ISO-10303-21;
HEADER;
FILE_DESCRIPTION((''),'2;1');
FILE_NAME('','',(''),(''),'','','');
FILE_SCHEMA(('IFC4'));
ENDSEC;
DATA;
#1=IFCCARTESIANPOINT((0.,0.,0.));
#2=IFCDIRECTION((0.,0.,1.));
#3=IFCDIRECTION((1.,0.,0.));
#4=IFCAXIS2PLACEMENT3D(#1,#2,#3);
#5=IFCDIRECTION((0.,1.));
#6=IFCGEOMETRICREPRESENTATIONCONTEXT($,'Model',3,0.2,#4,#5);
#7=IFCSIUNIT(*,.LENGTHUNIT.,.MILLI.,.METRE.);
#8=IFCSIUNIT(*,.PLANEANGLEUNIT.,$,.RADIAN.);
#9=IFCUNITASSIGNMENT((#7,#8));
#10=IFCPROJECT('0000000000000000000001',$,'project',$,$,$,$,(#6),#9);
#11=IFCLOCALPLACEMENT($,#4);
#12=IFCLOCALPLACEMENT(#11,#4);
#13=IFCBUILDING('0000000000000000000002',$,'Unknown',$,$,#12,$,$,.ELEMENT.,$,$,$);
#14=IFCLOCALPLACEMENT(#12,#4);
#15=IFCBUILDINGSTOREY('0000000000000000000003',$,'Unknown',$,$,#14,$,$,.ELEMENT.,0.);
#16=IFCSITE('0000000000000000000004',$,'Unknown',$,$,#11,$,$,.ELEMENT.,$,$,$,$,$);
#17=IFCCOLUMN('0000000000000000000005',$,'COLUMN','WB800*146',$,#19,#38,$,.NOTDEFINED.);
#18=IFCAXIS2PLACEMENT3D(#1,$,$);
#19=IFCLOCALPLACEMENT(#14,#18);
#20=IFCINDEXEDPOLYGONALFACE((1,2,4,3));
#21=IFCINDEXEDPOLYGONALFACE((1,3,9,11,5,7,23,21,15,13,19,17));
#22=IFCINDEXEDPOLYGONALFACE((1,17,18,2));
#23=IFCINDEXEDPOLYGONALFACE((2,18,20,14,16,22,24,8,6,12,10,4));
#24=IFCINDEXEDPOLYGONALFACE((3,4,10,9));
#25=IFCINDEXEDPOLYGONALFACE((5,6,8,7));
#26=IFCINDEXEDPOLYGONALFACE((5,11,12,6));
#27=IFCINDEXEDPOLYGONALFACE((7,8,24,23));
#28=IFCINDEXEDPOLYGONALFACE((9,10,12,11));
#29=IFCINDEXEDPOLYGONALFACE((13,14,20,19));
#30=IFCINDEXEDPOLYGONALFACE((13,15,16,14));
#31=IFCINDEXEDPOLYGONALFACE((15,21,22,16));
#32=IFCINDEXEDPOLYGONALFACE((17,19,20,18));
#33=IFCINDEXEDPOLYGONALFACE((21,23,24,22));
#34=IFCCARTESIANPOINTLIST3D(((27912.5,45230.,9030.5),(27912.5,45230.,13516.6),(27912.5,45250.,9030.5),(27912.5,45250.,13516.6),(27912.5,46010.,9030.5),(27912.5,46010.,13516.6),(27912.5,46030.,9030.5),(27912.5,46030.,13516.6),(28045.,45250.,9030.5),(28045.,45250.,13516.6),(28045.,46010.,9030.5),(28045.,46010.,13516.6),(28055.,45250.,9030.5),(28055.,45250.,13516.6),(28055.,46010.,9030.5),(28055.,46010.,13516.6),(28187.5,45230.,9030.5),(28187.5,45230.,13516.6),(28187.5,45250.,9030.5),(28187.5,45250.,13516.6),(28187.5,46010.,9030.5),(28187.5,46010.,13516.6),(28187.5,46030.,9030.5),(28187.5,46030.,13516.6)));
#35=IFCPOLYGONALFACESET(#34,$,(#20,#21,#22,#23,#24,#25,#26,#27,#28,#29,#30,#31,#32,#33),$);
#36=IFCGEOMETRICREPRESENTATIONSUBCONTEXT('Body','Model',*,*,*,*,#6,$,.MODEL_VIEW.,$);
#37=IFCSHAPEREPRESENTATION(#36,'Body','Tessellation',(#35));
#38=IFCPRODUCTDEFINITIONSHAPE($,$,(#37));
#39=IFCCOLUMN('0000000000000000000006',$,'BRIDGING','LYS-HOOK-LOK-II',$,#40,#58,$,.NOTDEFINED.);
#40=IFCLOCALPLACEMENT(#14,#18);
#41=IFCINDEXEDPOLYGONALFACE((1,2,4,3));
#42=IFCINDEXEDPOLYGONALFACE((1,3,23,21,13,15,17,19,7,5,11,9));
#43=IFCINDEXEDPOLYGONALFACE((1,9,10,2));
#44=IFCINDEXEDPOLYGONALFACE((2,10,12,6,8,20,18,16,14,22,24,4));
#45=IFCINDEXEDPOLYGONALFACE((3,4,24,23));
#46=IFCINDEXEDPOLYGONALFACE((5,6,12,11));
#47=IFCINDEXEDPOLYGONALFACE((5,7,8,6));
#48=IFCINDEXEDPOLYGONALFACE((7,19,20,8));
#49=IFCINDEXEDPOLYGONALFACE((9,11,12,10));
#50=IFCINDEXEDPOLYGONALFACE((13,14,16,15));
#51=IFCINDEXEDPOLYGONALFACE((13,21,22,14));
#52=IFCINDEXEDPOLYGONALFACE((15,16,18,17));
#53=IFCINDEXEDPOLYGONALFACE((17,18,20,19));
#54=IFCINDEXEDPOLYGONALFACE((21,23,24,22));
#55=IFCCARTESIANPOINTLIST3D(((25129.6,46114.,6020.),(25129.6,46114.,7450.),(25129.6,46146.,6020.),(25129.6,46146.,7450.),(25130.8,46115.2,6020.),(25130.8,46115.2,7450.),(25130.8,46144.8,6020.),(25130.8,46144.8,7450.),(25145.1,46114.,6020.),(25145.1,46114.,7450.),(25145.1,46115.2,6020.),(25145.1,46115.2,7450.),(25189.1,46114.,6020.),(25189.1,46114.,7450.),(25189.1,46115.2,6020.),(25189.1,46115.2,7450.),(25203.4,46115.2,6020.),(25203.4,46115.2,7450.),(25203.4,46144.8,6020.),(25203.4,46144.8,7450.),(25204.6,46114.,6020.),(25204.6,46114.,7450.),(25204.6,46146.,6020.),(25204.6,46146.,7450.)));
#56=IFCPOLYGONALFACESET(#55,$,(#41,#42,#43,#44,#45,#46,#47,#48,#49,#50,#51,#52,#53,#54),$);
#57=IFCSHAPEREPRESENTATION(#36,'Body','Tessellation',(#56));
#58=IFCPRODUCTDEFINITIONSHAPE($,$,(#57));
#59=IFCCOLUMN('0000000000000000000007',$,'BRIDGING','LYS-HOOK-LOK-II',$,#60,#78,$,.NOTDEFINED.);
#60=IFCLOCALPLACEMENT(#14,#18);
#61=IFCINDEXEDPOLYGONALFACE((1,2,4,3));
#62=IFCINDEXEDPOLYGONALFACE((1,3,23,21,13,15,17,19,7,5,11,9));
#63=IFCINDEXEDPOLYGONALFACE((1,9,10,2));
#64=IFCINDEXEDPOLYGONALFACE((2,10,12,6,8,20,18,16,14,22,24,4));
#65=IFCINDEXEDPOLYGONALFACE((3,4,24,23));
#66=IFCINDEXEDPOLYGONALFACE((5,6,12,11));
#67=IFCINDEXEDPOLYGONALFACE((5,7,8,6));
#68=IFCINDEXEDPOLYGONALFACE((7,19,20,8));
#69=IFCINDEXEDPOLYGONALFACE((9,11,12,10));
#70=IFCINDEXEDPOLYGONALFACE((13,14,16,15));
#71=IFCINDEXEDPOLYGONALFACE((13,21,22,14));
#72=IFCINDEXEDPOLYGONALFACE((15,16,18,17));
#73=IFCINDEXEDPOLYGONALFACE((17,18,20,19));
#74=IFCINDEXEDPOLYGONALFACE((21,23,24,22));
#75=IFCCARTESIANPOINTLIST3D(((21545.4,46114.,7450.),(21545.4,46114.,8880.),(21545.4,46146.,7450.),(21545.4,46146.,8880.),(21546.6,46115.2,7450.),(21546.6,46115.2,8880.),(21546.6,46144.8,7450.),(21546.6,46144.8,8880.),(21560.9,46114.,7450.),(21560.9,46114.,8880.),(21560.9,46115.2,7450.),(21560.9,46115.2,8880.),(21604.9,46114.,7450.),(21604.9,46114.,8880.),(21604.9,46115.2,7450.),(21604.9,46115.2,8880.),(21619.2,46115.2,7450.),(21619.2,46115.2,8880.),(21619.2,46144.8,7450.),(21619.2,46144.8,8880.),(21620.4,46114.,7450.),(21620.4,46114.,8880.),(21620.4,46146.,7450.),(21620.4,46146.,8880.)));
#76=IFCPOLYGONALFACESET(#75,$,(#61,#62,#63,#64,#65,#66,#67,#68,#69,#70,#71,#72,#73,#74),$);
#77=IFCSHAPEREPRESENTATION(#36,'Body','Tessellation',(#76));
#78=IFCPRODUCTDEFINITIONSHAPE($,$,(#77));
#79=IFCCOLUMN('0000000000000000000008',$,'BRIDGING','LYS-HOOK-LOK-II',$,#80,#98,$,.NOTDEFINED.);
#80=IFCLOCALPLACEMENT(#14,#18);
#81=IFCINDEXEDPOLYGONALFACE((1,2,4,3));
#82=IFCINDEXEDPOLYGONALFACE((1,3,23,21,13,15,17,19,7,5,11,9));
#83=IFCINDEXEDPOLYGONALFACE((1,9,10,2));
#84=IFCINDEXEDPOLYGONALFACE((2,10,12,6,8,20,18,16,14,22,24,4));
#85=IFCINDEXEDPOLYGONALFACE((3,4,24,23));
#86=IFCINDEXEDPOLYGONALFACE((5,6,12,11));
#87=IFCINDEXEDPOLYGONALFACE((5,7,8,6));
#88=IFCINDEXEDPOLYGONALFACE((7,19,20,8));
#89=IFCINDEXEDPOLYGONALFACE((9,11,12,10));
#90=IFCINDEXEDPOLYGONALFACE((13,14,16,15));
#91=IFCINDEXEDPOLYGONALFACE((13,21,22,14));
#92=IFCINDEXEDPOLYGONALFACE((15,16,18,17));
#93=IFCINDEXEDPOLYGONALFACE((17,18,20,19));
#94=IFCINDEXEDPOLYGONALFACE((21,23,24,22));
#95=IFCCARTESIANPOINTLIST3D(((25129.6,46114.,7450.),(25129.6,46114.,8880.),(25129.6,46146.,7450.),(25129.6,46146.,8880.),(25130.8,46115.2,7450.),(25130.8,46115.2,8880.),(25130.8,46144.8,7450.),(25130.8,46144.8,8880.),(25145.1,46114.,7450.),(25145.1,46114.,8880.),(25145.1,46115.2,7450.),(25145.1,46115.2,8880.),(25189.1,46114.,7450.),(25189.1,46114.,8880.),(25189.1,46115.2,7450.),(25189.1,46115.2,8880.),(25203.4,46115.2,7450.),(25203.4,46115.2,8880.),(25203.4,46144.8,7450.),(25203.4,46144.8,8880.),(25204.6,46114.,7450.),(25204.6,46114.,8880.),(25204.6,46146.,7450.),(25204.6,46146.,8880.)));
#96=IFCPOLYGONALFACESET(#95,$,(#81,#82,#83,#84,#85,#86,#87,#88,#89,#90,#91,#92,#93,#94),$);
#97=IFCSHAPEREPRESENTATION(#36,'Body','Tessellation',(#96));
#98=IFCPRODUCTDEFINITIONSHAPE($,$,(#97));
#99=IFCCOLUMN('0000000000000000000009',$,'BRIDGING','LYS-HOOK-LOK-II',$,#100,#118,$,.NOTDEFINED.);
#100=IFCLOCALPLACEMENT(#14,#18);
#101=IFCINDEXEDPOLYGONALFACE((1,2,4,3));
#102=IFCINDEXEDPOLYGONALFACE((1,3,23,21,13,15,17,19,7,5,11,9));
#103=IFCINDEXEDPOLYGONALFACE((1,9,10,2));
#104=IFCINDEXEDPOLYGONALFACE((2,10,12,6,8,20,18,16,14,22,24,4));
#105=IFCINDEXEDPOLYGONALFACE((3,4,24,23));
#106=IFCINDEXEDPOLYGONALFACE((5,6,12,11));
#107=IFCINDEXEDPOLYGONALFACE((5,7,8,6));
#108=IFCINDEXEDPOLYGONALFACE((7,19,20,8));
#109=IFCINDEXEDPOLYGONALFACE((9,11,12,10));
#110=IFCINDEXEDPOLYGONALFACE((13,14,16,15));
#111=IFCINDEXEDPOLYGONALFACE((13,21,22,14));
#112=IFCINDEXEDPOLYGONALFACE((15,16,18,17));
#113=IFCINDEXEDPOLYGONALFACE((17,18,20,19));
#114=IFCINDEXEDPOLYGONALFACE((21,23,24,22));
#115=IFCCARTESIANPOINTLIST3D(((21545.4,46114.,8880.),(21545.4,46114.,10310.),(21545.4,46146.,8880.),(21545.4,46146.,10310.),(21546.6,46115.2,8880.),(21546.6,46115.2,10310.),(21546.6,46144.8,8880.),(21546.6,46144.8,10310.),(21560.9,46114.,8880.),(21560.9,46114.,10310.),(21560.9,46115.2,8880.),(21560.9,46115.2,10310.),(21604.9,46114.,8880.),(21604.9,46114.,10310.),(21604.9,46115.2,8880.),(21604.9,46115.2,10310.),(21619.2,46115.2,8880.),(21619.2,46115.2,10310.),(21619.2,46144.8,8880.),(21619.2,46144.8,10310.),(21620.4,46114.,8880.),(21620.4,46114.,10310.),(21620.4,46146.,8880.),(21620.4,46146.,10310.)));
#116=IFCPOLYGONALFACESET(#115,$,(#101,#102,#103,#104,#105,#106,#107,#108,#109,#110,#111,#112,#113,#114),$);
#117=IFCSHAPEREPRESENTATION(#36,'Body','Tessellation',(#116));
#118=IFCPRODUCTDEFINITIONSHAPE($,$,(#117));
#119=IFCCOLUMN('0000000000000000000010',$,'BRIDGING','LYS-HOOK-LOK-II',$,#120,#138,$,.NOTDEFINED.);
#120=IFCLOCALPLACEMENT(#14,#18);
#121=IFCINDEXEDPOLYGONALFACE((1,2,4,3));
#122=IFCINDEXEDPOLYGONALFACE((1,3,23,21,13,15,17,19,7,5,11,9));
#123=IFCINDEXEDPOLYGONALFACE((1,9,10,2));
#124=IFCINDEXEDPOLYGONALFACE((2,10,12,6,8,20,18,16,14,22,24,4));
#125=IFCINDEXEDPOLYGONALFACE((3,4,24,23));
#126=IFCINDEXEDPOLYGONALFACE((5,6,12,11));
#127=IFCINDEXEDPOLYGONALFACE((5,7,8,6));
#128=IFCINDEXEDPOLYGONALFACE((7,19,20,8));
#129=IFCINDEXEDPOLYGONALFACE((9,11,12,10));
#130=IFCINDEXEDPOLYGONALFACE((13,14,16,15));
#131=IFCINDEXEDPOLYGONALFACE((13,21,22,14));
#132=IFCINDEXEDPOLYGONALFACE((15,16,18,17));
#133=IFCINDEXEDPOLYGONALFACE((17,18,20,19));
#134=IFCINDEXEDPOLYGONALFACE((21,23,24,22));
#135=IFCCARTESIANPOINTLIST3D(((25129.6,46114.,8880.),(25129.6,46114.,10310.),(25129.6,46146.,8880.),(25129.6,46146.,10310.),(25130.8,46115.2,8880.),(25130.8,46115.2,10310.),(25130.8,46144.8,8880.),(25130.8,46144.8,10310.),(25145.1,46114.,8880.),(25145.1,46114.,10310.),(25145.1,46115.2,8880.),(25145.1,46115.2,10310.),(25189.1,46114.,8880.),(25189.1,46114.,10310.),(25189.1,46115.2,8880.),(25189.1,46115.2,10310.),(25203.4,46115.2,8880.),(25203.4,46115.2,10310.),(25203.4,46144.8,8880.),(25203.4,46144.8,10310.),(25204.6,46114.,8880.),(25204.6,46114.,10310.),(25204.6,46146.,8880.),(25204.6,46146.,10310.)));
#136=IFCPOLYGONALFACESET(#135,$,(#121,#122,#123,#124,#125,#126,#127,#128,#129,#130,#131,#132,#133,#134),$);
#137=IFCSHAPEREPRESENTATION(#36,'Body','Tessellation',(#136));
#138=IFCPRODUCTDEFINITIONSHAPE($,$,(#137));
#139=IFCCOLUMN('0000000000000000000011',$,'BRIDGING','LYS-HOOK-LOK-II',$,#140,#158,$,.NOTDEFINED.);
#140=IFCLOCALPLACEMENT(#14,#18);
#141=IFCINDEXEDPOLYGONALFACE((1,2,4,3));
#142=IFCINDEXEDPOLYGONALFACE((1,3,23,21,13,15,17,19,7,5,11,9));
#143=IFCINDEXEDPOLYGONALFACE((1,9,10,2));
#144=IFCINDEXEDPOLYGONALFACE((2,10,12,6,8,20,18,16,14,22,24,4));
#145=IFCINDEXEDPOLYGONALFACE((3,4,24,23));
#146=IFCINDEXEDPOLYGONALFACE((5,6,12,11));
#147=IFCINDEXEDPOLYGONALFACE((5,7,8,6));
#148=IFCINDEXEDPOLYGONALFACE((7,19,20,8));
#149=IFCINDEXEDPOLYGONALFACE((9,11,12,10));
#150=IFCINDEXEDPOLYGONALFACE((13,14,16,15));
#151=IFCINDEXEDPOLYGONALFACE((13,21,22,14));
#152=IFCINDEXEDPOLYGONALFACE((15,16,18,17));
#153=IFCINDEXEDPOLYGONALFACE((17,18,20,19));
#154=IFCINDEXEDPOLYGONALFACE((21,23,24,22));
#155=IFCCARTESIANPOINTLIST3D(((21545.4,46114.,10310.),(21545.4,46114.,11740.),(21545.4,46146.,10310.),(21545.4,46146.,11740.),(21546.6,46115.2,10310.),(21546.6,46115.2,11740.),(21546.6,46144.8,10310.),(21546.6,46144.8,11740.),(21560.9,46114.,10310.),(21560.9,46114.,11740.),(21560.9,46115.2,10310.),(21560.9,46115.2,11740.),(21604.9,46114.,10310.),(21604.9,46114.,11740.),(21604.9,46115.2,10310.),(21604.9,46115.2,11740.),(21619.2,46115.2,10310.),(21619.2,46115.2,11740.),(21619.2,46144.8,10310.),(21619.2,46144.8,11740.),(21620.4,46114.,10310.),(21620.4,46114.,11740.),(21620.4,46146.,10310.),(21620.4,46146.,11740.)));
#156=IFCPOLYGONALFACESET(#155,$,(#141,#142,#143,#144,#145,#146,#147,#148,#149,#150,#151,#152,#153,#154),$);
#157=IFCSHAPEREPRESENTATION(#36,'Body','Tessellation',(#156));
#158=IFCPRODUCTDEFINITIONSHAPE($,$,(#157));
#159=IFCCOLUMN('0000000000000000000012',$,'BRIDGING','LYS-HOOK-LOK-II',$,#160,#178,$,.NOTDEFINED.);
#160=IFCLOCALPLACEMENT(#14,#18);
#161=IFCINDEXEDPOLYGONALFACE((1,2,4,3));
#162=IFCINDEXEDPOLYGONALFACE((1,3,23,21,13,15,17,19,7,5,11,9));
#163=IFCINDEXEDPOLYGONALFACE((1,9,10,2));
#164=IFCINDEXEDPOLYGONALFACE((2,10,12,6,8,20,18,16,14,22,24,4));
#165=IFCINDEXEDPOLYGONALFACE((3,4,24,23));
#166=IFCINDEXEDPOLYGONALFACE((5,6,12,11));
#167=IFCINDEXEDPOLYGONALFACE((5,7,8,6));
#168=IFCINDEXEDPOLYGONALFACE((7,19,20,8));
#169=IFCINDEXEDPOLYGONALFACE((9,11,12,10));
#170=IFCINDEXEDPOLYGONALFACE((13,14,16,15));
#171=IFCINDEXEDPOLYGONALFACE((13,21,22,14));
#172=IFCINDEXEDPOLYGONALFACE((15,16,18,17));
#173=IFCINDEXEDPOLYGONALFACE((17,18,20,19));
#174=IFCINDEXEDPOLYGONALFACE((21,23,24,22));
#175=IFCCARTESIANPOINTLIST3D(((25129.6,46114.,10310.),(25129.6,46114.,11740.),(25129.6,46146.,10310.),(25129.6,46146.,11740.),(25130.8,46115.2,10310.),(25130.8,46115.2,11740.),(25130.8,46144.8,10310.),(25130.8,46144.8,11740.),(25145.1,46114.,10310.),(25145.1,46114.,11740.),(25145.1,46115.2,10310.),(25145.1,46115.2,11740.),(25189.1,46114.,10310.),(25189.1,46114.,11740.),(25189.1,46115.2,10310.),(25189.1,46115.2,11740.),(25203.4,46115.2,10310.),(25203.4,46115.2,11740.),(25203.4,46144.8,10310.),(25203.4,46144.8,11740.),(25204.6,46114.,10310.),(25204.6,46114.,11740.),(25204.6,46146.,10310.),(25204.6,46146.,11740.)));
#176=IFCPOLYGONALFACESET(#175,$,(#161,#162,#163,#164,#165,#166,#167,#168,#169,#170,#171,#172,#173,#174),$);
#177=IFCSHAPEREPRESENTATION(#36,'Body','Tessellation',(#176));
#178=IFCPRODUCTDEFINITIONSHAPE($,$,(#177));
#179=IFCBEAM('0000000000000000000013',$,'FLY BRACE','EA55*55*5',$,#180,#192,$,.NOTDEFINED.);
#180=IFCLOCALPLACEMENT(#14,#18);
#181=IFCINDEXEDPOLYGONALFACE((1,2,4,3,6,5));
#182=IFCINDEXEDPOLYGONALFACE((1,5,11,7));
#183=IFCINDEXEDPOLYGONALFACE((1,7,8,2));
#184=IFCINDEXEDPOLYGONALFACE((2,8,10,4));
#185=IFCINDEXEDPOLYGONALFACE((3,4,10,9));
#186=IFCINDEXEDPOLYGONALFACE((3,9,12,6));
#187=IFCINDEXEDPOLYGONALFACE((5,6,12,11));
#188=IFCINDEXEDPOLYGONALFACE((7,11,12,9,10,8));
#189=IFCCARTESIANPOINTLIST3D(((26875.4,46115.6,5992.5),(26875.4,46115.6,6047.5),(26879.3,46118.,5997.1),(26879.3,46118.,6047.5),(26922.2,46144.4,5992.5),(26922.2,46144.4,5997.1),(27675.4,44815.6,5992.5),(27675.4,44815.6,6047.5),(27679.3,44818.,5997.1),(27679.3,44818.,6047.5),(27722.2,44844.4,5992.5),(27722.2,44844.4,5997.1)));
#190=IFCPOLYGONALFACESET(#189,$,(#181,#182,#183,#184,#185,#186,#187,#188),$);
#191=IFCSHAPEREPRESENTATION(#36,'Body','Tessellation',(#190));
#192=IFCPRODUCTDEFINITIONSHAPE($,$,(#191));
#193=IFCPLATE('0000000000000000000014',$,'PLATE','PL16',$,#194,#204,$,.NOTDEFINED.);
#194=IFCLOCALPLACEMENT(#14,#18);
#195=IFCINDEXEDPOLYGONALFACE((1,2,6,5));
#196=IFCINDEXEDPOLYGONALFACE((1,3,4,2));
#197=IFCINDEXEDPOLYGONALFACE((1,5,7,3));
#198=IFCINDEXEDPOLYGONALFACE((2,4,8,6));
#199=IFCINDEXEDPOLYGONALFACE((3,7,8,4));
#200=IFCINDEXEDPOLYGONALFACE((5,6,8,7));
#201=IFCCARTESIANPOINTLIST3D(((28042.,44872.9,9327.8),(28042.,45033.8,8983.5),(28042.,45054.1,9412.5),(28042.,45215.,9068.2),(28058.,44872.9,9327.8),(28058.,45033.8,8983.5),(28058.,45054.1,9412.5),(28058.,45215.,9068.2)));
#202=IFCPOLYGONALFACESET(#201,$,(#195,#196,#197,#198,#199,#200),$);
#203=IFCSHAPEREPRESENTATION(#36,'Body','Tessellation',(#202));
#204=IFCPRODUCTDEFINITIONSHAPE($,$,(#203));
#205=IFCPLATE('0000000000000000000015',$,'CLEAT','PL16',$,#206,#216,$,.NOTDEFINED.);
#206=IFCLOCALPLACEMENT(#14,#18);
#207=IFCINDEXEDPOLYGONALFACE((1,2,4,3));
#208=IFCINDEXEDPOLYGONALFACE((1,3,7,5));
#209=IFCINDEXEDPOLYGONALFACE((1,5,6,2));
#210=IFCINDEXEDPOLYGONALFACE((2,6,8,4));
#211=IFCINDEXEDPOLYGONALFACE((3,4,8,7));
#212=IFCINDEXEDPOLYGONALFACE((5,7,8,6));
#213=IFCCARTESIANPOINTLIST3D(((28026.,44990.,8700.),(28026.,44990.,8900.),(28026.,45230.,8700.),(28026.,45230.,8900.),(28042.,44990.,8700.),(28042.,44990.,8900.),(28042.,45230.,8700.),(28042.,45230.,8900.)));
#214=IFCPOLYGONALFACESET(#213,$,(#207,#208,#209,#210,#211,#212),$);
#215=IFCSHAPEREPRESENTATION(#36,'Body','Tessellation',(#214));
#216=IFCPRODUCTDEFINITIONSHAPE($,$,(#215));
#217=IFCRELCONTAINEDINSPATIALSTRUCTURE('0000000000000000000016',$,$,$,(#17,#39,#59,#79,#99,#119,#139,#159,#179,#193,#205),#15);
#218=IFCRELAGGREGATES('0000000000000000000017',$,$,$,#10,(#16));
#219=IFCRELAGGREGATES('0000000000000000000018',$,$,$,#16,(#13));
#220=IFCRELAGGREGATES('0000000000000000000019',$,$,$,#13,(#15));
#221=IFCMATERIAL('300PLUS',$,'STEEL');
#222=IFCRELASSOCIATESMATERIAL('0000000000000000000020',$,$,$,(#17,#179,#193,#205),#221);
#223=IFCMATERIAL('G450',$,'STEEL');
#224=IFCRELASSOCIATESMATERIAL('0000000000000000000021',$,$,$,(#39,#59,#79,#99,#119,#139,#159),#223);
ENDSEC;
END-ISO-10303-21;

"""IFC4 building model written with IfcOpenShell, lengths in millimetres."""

from ifc_helpers import new_model, si_unit, direction, frame, origin_with_axes, place, context, subcontext, project, spatial, line, indexed_curve, outline, extrude, material, element, save


model = new_model("IFC4")

# Units and contexts
model_context = context("Model", 3, precision=0.2, world=origin_with_axes(), true_north=direction((0.0, 1.0)))
body_context = subcontext(model_context, "Body", "Model", "MODEL_VIEW")
ifc_project = project(units=[si_unit("LENGTHUNIT", "METRE", prefix="MILLI"), si_unit("PLANEANGLEUNIT", "RADIAN")], contexts=[model_context])

# Site, building, storey
site_placement = place(None, origin_with_axes())
site = spatial("IfcSite", under=ifc_project, at=site_placement, Name="Unknown", CompositionType="ELEMENT")
building_placement = place(site_placement, origin_with_axes())
building = spatial("IfcBuilding", under=site, at=building_placement, Name="Unknown", CompositionType="ELEMENT")
storey_placement = place(building_placement, origin_with_axes())
storey = spatial("IfcBuildingStorey", under=building, at=storey_placement, Name="Unknown", CompositionType="ELEMENT", Elevation=0.0)

# Columns
ifc_material_1 = material(Name="300PLUS", Category="STEEL")
column_placement = place(storey_placement, frame((28050.0, 45630.0, 9030.5), z_axis=(-1.0, 0.0, 0.0), x_axis=(0.0, 0.0, 1.0)))
element("IfcColumn", 1, at=column_placement, inside=storey, material=ifc_material_1, Name="COLUMN", Description="WB800*146", PredefinedType="NOTDEFINED", context=body_context, shape_type="SolidModel", body=[
    extrude(outline(indexed_curve([(-137.5, -400.0), (137.5, -400.0), (137.5, -380.0), (5.0, -380.0), (5.0, 380.0), (137.5, 380.0), (137.5, 400.0), (-137.5, 400.0), (-137.5, 380.0), (-5.0, 380.0), (-5.0, -380.0), (-137.5, -380.0)], segments=[line(1, 2, 3, 4, 5, 6, 7, 8, 9, 10, 11, 12, 1)])), frame((0.0, 0.0, 0.0), z_axis=(-1.0, 0.0, 0.0), x_axis=(0.0, 0.0, 1.0)), (0.0, 0.0, -1.0), 4486.1),
])
ifc_material_2 = material(Name="G450", Category="STEEL")
for number, where, z_axis, x_axis, name in (
    (2, (25167.1, 46130.0, 6020.0), (0.0, -1.0, 0.0), (0.0, 0.0, 1.0), "BRIDGING"),
    (3, (21582.9, 46130.0, 7450.0), (0.0, -1.0, 0.0), (0.0, 0.0, 1.0), "BRIDGING"),
    (4, (25167.1, 46130.0, 7450.0), (0.0, -1.0, 0.0), (0.0, 0.0, 1.0), "BRIDGING"),
    (5, (21582.9, 46130.0, 8880.0), (0.0, -1.0, 0.0), (0.0, 0.0, 1.0), "BRIDGING"),
    (6, (25167.1, 46130.0, 8880.0), (0.0, -1.0, 0.0), (0.0, 0.0, 1.0), "BRIDGING"),
    (7, (21582.9, 46130.0, 10310.0), (0.0, -1.0, 0.0), (0.0, 0.0, 1.0), "BRIDGING"),
    (8, (25167.1, 46130.0, 10310.0), (0.0, -1.0, 0.0), (0.0, 0.0, 1.0), "BRIDGING"),
):
    element("IfcColumn", number, at=place(storey_placement, frame(where, z_axis=z_axis, x_axis=x_axis)), inside=storey, material=ifc_material_2, Name=name, Description="LYS-HOOK-LOK-II", PredefinedType="NOTDEFINED", context=body_context, shape_type="SolidModel", body=[
        extrude(outline(indexed_curve([(16.0, -37.5), (16.0, -22.0), (14.8, -22.0), (14.8, -36.3), (-14.8, -36.3), (-14.8, 36.3), (14.8, 36.3), (14.8, 22.0), (16.0, 22.0), (16.0, 37.5), (-16.0, 37.5), (-16.0, -37.5)], segments=[line(1, 2, 3, 4, 5, 6, 7, 8, 9, 10, 11, 12, 1)])), frame((0.0, 0.0, 0.0), z_axis=(-1.0, 0.0, 0.0), x_axis=(0.0, 0.0, 1.0)), (0.0, 0.0, -1.0), 1430.0),
    ])

# Beam
beam_placement = place(storey_placement, frame((26898.8, 46130.0, 6020.0), z_axis=(0.0, 0.0, 1.0), x_axis=(0.524097, -0.851658, 0.0)))
element("IfcBeam", 9, at=beam_placement, inside=storey, material=ifc_material_1, Name="FLY BRACE", Description="EA55*55*5", PredefinedType="NOTDEFINED", context=body_context, shape_type="SolidModel", body=[
    extrude(outline(indexed_curve([(-27.5, -27.5), (27.5, -27.5), (27.5, -22.9), (-22.9, -22.9), (-22.9, 27.5), (-27.5, 27.5)], segments=[line(1, 2, 3, 4, 5, 6, 1)])), frame((0.0, 0.0, 0.0), z_axis=(-1.0, 0.0, 0.0), x_axis=(0.0, 0.0, 1.0)), (0.0, 0.0, -1.0), 1526.4),
])

# Plates
plate_1_placement = place(storey_placement, frame((28050.0, 45054.1, 9412.5), z_axis=(-1.0, 0.0, 0.0), x_axis=(0.0, 0.423375, -0.905954)))
element("IfcPlate", 10, at=plate_1_placement, inside=storey, material=ifc_material_1, Name="PLATE", Description="PL16", PredefinedType="NOTDEFINED", context=body_context, shape_type="SolidModel", body=[
    extrude(outline(indexed_curve([(0.0, 0.0), (380.0, 0.0), (380.1, 200.0), (0.0, 200.0)], segments=[line(1, 2, 3, 4, 1)])), frame((0.0, 0.0, 8.0), z_axis=(0.0, 0.0, 1.0), x_axis=(1.0, 0.0, 0.0)), (0.0, 0.0, -1.0), 16.0),
])
plate_2_placement = place(storey_placement, frame((28034.0, 45230.0, 8700.0), z_axis=(-1.0, 0.0, 0.0), x_axis=(0.0, -1.0, 0.0)))
element("IfcPlate", 11, at=plate_2_placement, inside=storey, material=ifc_material_1, Name="CLEAT", Description="PL16", PredefinedType="NOTDEFINED", context=body_context, shape_type="SolidModel", body=[
    extrude(outline(indexed_curve([(0.0, 0.0), (240.0, 0.0), (240.0, 200.0), (0.0, 200.0)], segments=[line(1, 2, 3, 4, 1)])), frame((0.0, 0.0, 8.0), z_axis=(0.0, 0.0, 1.0), x_axis=(1.0, 0.0, 0.0)), (0.0, 0.0, -1.0), 16.0),
])

save(model, "model.ifc")
